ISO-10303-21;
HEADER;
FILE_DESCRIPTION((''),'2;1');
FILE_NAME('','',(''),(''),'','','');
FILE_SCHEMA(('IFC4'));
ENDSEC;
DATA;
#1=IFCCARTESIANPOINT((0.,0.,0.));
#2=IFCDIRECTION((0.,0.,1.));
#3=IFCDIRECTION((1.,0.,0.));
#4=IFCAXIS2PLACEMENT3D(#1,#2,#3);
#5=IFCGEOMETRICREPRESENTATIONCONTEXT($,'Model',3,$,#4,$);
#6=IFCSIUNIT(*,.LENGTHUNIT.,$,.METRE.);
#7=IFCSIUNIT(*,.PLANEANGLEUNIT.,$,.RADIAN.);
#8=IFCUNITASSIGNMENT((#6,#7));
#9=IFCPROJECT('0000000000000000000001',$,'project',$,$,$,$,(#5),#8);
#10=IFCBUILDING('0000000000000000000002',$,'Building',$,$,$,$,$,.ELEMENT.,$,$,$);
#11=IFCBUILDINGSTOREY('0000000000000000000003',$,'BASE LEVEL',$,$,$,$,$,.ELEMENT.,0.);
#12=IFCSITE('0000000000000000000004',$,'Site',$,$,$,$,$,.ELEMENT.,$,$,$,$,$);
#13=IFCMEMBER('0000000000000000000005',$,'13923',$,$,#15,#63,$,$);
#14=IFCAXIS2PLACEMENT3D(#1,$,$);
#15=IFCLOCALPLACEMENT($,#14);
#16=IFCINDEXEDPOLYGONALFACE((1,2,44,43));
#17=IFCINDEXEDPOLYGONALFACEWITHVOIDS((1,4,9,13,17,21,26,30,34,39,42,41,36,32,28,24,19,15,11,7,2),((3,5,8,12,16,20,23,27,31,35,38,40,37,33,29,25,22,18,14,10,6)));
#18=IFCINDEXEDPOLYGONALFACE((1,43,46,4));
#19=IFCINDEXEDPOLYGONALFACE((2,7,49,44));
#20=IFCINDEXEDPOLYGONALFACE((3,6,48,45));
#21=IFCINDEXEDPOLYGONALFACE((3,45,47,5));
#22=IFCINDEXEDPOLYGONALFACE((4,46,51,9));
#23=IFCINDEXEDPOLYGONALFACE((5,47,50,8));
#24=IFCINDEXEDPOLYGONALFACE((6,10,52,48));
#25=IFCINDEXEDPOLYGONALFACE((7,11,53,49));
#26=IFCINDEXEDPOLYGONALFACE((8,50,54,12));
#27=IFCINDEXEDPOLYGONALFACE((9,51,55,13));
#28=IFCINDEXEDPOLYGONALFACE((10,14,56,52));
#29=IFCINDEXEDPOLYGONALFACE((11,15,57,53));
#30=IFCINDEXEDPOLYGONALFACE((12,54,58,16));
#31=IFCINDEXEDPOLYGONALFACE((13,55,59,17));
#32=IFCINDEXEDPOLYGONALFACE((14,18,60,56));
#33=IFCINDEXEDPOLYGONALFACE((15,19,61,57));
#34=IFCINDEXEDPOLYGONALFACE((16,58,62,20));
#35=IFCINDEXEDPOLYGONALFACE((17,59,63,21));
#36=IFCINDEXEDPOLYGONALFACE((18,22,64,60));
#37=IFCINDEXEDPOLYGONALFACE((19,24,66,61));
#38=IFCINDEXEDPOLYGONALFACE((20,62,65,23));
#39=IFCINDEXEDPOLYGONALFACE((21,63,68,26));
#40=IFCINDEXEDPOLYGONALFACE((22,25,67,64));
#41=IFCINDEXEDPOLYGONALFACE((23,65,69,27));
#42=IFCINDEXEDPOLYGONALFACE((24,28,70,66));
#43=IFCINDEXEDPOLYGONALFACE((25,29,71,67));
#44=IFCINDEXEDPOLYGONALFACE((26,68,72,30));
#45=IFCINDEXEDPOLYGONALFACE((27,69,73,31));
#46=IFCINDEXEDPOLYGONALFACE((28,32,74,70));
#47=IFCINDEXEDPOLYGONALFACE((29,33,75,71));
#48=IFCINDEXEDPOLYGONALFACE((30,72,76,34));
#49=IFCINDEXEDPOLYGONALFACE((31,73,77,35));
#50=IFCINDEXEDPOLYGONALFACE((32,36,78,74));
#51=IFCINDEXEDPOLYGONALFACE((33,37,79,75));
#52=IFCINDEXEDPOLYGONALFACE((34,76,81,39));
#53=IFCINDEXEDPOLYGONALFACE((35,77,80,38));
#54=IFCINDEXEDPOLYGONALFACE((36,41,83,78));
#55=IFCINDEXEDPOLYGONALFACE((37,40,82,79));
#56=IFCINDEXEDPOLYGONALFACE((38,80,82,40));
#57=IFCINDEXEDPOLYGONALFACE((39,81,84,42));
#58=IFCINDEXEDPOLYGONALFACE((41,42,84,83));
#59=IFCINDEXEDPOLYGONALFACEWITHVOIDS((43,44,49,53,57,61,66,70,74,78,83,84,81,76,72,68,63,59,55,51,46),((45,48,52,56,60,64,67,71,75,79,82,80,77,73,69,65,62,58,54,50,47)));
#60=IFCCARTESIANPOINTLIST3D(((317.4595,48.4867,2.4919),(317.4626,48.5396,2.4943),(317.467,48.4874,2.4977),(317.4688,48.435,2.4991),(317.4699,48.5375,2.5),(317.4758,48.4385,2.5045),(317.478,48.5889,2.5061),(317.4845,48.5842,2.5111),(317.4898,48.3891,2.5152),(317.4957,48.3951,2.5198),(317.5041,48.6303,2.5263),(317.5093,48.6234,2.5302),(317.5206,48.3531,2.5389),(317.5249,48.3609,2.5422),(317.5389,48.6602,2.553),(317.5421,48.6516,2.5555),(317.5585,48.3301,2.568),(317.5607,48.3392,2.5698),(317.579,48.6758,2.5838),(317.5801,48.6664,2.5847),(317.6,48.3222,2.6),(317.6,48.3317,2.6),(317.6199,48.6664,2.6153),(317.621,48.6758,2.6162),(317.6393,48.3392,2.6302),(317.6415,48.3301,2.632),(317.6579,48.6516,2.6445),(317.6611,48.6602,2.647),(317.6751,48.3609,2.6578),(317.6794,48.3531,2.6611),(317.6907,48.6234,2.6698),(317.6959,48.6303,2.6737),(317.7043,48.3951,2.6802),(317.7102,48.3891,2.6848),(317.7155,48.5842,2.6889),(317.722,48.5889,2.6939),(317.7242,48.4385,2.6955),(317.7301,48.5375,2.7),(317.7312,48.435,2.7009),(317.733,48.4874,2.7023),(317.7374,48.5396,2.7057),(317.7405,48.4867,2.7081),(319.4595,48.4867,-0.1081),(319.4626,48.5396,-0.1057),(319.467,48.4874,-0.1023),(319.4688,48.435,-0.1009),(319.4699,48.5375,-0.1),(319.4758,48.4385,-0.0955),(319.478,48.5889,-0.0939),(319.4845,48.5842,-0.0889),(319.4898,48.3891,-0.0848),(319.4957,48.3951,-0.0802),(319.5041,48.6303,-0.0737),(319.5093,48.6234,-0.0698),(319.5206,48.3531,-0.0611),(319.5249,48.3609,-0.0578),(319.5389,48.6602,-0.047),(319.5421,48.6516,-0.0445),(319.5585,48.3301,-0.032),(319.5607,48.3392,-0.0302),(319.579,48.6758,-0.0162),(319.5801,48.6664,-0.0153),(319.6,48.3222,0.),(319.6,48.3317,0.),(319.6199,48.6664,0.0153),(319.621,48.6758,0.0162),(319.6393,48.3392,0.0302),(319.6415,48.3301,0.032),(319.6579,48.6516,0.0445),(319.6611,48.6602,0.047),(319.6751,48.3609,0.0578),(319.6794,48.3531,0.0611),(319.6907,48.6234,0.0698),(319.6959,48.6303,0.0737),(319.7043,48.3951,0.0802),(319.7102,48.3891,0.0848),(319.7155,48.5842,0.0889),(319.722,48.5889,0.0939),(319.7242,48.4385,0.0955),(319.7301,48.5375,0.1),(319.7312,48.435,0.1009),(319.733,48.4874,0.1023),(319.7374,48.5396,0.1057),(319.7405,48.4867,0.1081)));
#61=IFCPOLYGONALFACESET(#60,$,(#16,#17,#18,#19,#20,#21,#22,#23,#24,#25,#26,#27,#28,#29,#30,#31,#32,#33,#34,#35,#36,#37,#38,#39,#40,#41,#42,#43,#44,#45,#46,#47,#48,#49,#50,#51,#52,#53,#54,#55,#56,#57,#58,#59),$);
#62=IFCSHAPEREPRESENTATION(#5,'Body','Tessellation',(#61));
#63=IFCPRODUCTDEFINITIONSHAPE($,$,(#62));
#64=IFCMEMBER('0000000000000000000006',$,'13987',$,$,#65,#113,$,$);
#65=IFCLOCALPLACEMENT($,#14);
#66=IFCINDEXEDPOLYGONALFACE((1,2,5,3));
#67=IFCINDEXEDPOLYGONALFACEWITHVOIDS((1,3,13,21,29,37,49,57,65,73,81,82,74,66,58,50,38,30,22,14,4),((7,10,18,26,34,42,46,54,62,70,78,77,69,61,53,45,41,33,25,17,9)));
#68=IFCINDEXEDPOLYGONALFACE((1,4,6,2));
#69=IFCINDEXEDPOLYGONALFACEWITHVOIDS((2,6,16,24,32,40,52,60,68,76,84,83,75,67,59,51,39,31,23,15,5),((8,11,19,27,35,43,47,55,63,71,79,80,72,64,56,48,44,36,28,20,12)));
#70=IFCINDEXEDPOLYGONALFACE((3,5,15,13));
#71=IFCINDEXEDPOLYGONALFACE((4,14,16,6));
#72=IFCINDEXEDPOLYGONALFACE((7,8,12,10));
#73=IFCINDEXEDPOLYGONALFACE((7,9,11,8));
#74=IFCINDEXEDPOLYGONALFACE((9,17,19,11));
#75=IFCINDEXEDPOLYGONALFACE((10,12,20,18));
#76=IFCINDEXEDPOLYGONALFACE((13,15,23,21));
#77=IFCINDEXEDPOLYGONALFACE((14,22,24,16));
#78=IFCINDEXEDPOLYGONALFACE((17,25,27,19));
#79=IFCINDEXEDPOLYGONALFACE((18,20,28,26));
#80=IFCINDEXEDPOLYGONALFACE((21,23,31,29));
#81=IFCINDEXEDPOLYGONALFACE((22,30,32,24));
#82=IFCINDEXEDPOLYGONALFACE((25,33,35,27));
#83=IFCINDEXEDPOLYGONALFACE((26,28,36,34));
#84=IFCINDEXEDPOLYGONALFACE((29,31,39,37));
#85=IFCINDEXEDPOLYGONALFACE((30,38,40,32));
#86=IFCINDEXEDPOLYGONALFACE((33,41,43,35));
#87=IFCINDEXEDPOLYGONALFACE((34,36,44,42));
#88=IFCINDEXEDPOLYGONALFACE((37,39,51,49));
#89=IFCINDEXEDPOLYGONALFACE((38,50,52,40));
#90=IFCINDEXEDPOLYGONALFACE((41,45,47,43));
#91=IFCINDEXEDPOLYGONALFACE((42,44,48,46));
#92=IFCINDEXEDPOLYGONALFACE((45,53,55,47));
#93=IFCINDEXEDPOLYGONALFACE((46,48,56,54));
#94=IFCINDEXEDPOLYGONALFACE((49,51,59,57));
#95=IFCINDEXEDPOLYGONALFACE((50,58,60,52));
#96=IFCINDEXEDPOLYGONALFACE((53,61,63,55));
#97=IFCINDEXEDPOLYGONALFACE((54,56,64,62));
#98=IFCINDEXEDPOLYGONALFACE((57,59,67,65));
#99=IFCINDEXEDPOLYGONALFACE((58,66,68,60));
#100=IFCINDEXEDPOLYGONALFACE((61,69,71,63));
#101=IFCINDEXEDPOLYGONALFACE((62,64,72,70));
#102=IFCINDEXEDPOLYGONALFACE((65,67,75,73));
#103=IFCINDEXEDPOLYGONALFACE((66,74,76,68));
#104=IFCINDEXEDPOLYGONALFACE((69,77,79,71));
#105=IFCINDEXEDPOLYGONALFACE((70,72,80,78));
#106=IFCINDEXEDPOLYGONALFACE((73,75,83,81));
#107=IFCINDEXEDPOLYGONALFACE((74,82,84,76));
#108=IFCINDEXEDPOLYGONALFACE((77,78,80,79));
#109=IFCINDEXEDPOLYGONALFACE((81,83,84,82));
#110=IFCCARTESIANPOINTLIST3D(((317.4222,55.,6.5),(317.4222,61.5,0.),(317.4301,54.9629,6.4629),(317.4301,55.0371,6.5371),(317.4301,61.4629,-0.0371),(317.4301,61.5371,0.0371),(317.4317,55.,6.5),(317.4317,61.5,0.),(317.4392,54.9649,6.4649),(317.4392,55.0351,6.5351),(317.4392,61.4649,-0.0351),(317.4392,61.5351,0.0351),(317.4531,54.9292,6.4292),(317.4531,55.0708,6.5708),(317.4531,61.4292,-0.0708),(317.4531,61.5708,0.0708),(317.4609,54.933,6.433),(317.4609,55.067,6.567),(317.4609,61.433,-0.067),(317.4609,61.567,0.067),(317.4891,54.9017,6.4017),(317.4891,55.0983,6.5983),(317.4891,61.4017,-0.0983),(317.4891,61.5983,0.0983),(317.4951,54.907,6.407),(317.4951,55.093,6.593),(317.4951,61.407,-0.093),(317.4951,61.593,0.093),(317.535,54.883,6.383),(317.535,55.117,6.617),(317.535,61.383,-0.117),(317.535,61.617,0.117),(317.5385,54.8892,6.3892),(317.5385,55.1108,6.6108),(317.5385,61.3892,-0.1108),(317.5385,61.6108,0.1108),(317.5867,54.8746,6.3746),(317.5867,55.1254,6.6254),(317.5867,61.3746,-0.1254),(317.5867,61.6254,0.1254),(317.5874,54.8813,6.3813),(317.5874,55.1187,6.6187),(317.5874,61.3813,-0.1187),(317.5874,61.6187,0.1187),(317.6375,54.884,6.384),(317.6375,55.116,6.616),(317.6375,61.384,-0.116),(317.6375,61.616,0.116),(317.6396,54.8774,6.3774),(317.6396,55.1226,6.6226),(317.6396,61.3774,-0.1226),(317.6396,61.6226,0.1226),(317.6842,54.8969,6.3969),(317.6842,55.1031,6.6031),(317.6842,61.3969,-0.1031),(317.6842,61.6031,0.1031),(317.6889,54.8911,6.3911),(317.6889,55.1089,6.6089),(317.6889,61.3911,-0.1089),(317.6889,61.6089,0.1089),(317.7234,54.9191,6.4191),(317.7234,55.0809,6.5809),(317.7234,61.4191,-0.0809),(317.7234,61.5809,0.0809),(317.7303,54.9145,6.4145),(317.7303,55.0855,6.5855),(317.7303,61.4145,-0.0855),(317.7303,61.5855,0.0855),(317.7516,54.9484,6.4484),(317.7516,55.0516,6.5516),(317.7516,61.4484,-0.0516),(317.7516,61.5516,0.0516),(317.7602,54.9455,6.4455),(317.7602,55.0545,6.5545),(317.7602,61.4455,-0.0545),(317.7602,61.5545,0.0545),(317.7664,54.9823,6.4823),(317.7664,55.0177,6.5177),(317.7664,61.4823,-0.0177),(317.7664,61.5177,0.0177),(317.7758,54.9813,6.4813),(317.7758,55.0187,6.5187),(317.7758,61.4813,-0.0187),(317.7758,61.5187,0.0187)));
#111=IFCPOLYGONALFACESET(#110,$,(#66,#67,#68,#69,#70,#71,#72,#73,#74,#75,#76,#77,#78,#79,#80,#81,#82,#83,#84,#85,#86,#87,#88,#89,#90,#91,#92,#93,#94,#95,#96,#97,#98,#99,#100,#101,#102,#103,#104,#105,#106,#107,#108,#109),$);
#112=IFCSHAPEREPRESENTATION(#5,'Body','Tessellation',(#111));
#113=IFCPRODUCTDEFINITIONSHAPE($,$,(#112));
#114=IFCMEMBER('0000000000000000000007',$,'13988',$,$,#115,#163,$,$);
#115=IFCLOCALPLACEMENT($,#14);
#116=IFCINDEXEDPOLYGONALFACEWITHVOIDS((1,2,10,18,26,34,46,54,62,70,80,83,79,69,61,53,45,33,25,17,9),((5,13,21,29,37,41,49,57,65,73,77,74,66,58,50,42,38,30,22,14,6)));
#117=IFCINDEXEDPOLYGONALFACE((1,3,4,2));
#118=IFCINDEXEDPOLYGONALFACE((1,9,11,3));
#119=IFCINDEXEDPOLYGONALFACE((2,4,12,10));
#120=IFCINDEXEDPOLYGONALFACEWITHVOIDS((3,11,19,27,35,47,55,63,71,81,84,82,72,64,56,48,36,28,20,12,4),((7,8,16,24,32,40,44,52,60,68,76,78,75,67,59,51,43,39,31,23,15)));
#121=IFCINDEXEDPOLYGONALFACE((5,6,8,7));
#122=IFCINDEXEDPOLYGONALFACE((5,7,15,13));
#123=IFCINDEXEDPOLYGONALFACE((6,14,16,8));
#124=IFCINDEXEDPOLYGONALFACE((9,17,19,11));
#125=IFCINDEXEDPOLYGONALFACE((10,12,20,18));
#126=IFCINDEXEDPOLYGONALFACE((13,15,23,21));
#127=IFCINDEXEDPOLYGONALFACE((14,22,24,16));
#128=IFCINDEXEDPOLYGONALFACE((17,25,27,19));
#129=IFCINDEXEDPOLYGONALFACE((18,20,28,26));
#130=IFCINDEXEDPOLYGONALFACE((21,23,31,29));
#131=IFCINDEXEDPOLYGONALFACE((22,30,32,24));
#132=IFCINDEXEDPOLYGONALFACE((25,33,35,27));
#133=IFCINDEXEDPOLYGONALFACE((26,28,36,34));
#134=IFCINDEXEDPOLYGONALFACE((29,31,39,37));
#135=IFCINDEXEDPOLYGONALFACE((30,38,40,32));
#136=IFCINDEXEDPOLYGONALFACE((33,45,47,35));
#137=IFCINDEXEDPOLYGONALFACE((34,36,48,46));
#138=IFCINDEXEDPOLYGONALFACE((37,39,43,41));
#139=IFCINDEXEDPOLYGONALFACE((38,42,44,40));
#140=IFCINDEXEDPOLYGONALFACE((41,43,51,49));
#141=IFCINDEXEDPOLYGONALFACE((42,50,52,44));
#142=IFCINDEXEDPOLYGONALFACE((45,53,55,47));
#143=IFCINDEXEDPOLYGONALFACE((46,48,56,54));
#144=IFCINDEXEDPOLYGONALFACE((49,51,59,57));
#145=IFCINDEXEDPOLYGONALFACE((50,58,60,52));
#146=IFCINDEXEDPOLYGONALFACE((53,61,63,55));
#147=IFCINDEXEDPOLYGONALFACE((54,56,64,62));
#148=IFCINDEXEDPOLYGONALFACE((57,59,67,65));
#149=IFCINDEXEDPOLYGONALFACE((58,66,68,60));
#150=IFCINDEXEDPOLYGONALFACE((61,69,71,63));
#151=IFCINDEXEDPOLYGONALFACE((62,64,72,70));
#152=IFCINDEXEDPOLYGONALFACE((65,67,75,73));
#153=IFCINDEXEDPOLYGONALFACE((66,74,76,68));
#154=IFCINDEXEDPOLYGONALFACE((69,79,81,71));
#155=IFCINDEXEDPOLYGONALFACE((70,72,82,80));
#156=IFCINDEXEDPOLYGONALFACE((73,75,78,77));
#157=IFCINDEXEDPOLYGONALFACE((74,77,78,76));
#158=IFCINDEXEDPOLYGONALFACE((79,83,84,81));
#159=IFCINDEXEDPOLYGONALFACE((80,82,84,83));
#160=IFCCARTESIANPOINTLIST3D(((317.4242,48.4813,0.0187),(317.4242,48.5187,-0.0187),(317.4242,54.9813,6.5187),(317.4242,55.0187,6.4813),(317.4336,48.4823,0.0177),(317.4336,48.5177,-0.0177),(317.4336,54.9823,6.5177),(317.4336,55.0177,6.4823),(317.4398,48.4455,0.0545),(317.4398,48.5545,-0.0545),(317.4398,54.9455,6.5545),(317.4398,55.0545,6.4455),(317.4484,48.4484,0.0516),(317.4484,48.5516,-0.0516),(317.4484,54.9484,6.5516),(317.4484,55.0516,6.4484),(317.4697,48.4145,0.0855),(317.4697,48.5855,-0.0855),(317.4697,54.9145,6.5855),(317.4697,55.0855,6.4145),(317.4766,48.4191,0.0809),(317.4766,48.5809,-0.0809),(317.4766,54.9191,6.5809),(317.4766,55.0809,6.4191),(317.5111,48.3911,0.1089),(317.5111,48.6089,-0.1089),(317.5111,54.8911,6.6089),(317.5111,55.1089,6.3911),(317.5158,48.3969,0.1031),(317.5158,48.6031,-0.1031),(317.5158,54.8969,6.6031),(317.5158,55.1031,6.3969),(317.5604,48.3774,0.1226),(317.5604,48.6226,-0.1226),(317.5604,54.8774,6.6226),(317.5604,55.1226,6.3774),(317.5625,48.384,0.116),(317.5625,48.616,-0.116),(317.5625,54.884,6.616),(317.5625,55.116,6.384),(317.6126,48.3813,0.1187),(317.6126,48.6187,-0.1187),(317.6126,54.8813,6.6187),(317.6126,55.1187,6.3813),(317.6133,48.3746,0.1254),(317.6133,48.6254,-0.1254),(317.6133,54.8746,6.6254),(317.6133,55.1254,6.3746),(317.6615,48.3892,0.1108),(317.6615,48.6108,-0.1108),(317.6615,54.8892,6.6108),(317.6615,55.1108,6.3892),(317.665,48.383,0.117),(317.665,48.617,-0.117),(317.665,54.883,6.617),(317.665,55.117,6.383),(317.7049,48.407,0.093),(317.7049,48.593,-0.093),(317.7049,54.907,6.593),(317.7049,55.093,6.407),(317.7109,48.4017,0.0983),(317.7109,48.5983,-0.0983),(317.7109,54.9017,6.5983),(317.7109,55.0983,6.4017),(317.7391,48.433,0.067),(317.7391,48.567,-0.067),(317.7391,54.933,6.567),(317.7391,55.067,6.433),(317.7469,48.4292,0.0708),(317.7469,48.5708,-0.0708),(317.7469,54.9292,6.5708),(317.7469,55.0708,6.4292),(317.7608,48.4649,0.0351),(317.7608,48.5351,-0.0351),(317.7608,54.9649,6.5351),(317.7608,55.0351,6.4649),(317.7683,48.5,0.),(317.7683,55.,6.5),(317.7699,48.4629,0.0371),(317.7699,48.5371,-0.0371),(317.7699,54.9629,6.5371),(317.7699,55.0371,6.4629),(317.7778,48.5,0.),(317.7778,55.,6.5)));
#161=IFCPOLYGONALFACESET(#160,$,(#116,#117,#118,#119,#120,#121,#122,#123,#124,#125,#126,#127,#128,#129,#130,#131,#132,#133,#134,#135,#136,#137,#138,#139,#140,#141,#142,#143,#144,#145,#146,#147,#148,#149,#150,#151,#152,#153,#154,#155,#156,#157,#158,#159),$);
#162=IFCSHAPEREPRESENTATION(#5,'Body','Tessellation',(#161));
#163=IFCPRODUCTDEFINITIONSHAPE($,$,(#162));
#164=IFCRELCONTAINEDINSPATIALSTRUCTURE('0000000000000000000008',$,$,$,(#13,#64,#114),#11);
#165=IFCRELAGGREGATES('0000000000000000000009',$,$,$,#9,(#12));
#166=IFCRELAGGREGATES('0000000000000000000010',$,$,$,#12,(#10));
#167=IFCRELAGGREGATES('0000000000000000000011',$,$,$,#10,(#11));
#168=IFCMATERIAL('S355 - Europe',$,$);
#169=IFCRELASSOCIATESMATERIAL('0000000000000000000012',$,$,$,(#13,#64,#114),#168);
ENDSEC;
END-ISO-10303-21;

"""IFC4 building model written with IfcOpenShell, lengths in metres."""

from ifc_helpers import new_model, si_unit, frame, origin_with_axes, origin_2d_with_axis, place, context, project, spatial, hollow_circle, extrude, material, material_profile, profile_set, profile_usage, element, save


model = new_model("IFC4")

# Units and contexts
model_context = context("Model", 3, world=origin_with_axes())
ifc_project = project(units=[si_unit("LENGTHUNIT", "METRE"), si_unit("PLANEANGLEUNIT", "RADIAN")], contexts=[model_context])

# Site, building, storey
site = spatial("IfcSite", under=ifc_project, Name="Site", CompositionType="ELEMENT")
building = spatial("IfcBuilding", under=site, Name="Building", CompositionType="ELEMENT")
storey = spatial("IfcBuildingStorey", under=building, Name="BASE LEVEL", CompositionType="ELEMENT", Elevation=0.0)

# Shared definitions
ifc_material = material(Name="S355 - Europe")

# Members
ifc_material_profile_1 = material_profile(ifc_material, hollow_circle(Radius=0.1778, WallThickness=0.0095, at=origin_2d_with_axis()))
ifc_profile_set_1 = profile_set([ifc_material_profile_1])
ifc_profile_usage_1 = profile_usage(ifc_profile_set_1, cardinal=10)
member_1_placement = place(None, frame((319.6, 48.5, 0.0), z_axis=(-0.609711, 0.0, 0.792624), x_axis=(0.0, -1.0, 0.0)))
element("IfcMember", 1, at=member_1_placement, inside=storey, material=ifc_profile_usage_1, Name="13923", context=model_context, shape_type="SweptSolid", body=[
    extrude(hollow_circle(Radius=0.1778, WallThickness=0.0095, at=origin_2d_with_axis()), origin_with_axes(), (0.0, 0.0, 1.0), 3.2802),
])
ifc_material_profile_2 = material_profile(ifc_material, hollow_circle(Radius=0.1778, WallThickness=0.0095, at=origin_2d_with_axis()))
ifc_profile_set_2 = profile_set([ifc_material_profile_2])
ifc_profile_usage_2 = profile_usage(ifc_profile_set_2, cardinal=10)
member_2_placement = place(None, frame((317.6, 55.0, 6.5), z_axis=(0.0, 0.707107, -0.707107), x_axis=(-1.0, 0.0, 0.0)))
element("IfcMember", 2, at=member_2_placement, inside=storey, material=ifc_profile_usage_2, Name="13987", context=model_context, shape_type="SweptSolid", body=[
    extrude(hollow_circle(Radius=0.1778, WallThickness=0.0095, at=origin_2d_with_axis()), origin_with_axes(), (0.0, 0.0, 1.0), 9.1924),
])
ifc_material_profile_3 = material_profile(ifc_material, hollow_circle(Radius=0.1778, WallThickness=0.0095, at=origin_2d_with_axis()))
ifc_profile_set_3 = profile_set([ifc_material_profile_3])
ifc_profile_usage_3 = profile_usage(ifc_profile_set_3, cardinal=10)
member_3_placement = place(None, frame((317.6, 55.0, 6.5), z_axis=(0.0, -0.707107, -0.707107), x_axis=(1.0, 0.0, 0.0)))
element("IfcMember", 3, at=member_3_placement, inside=storey, material=ifc_profile_usage_3, Name="13988", context=model_context, shape_type="SweptSolid", body=[
    extrude(hollow_circle(Radius=0.1778, WallThickness=0.0095, at=origin_2d_with_axis()), origin_with_axes(), (0.0, 0.0, 1.0), 9.1924),
])

save(model, "model.ifc")
